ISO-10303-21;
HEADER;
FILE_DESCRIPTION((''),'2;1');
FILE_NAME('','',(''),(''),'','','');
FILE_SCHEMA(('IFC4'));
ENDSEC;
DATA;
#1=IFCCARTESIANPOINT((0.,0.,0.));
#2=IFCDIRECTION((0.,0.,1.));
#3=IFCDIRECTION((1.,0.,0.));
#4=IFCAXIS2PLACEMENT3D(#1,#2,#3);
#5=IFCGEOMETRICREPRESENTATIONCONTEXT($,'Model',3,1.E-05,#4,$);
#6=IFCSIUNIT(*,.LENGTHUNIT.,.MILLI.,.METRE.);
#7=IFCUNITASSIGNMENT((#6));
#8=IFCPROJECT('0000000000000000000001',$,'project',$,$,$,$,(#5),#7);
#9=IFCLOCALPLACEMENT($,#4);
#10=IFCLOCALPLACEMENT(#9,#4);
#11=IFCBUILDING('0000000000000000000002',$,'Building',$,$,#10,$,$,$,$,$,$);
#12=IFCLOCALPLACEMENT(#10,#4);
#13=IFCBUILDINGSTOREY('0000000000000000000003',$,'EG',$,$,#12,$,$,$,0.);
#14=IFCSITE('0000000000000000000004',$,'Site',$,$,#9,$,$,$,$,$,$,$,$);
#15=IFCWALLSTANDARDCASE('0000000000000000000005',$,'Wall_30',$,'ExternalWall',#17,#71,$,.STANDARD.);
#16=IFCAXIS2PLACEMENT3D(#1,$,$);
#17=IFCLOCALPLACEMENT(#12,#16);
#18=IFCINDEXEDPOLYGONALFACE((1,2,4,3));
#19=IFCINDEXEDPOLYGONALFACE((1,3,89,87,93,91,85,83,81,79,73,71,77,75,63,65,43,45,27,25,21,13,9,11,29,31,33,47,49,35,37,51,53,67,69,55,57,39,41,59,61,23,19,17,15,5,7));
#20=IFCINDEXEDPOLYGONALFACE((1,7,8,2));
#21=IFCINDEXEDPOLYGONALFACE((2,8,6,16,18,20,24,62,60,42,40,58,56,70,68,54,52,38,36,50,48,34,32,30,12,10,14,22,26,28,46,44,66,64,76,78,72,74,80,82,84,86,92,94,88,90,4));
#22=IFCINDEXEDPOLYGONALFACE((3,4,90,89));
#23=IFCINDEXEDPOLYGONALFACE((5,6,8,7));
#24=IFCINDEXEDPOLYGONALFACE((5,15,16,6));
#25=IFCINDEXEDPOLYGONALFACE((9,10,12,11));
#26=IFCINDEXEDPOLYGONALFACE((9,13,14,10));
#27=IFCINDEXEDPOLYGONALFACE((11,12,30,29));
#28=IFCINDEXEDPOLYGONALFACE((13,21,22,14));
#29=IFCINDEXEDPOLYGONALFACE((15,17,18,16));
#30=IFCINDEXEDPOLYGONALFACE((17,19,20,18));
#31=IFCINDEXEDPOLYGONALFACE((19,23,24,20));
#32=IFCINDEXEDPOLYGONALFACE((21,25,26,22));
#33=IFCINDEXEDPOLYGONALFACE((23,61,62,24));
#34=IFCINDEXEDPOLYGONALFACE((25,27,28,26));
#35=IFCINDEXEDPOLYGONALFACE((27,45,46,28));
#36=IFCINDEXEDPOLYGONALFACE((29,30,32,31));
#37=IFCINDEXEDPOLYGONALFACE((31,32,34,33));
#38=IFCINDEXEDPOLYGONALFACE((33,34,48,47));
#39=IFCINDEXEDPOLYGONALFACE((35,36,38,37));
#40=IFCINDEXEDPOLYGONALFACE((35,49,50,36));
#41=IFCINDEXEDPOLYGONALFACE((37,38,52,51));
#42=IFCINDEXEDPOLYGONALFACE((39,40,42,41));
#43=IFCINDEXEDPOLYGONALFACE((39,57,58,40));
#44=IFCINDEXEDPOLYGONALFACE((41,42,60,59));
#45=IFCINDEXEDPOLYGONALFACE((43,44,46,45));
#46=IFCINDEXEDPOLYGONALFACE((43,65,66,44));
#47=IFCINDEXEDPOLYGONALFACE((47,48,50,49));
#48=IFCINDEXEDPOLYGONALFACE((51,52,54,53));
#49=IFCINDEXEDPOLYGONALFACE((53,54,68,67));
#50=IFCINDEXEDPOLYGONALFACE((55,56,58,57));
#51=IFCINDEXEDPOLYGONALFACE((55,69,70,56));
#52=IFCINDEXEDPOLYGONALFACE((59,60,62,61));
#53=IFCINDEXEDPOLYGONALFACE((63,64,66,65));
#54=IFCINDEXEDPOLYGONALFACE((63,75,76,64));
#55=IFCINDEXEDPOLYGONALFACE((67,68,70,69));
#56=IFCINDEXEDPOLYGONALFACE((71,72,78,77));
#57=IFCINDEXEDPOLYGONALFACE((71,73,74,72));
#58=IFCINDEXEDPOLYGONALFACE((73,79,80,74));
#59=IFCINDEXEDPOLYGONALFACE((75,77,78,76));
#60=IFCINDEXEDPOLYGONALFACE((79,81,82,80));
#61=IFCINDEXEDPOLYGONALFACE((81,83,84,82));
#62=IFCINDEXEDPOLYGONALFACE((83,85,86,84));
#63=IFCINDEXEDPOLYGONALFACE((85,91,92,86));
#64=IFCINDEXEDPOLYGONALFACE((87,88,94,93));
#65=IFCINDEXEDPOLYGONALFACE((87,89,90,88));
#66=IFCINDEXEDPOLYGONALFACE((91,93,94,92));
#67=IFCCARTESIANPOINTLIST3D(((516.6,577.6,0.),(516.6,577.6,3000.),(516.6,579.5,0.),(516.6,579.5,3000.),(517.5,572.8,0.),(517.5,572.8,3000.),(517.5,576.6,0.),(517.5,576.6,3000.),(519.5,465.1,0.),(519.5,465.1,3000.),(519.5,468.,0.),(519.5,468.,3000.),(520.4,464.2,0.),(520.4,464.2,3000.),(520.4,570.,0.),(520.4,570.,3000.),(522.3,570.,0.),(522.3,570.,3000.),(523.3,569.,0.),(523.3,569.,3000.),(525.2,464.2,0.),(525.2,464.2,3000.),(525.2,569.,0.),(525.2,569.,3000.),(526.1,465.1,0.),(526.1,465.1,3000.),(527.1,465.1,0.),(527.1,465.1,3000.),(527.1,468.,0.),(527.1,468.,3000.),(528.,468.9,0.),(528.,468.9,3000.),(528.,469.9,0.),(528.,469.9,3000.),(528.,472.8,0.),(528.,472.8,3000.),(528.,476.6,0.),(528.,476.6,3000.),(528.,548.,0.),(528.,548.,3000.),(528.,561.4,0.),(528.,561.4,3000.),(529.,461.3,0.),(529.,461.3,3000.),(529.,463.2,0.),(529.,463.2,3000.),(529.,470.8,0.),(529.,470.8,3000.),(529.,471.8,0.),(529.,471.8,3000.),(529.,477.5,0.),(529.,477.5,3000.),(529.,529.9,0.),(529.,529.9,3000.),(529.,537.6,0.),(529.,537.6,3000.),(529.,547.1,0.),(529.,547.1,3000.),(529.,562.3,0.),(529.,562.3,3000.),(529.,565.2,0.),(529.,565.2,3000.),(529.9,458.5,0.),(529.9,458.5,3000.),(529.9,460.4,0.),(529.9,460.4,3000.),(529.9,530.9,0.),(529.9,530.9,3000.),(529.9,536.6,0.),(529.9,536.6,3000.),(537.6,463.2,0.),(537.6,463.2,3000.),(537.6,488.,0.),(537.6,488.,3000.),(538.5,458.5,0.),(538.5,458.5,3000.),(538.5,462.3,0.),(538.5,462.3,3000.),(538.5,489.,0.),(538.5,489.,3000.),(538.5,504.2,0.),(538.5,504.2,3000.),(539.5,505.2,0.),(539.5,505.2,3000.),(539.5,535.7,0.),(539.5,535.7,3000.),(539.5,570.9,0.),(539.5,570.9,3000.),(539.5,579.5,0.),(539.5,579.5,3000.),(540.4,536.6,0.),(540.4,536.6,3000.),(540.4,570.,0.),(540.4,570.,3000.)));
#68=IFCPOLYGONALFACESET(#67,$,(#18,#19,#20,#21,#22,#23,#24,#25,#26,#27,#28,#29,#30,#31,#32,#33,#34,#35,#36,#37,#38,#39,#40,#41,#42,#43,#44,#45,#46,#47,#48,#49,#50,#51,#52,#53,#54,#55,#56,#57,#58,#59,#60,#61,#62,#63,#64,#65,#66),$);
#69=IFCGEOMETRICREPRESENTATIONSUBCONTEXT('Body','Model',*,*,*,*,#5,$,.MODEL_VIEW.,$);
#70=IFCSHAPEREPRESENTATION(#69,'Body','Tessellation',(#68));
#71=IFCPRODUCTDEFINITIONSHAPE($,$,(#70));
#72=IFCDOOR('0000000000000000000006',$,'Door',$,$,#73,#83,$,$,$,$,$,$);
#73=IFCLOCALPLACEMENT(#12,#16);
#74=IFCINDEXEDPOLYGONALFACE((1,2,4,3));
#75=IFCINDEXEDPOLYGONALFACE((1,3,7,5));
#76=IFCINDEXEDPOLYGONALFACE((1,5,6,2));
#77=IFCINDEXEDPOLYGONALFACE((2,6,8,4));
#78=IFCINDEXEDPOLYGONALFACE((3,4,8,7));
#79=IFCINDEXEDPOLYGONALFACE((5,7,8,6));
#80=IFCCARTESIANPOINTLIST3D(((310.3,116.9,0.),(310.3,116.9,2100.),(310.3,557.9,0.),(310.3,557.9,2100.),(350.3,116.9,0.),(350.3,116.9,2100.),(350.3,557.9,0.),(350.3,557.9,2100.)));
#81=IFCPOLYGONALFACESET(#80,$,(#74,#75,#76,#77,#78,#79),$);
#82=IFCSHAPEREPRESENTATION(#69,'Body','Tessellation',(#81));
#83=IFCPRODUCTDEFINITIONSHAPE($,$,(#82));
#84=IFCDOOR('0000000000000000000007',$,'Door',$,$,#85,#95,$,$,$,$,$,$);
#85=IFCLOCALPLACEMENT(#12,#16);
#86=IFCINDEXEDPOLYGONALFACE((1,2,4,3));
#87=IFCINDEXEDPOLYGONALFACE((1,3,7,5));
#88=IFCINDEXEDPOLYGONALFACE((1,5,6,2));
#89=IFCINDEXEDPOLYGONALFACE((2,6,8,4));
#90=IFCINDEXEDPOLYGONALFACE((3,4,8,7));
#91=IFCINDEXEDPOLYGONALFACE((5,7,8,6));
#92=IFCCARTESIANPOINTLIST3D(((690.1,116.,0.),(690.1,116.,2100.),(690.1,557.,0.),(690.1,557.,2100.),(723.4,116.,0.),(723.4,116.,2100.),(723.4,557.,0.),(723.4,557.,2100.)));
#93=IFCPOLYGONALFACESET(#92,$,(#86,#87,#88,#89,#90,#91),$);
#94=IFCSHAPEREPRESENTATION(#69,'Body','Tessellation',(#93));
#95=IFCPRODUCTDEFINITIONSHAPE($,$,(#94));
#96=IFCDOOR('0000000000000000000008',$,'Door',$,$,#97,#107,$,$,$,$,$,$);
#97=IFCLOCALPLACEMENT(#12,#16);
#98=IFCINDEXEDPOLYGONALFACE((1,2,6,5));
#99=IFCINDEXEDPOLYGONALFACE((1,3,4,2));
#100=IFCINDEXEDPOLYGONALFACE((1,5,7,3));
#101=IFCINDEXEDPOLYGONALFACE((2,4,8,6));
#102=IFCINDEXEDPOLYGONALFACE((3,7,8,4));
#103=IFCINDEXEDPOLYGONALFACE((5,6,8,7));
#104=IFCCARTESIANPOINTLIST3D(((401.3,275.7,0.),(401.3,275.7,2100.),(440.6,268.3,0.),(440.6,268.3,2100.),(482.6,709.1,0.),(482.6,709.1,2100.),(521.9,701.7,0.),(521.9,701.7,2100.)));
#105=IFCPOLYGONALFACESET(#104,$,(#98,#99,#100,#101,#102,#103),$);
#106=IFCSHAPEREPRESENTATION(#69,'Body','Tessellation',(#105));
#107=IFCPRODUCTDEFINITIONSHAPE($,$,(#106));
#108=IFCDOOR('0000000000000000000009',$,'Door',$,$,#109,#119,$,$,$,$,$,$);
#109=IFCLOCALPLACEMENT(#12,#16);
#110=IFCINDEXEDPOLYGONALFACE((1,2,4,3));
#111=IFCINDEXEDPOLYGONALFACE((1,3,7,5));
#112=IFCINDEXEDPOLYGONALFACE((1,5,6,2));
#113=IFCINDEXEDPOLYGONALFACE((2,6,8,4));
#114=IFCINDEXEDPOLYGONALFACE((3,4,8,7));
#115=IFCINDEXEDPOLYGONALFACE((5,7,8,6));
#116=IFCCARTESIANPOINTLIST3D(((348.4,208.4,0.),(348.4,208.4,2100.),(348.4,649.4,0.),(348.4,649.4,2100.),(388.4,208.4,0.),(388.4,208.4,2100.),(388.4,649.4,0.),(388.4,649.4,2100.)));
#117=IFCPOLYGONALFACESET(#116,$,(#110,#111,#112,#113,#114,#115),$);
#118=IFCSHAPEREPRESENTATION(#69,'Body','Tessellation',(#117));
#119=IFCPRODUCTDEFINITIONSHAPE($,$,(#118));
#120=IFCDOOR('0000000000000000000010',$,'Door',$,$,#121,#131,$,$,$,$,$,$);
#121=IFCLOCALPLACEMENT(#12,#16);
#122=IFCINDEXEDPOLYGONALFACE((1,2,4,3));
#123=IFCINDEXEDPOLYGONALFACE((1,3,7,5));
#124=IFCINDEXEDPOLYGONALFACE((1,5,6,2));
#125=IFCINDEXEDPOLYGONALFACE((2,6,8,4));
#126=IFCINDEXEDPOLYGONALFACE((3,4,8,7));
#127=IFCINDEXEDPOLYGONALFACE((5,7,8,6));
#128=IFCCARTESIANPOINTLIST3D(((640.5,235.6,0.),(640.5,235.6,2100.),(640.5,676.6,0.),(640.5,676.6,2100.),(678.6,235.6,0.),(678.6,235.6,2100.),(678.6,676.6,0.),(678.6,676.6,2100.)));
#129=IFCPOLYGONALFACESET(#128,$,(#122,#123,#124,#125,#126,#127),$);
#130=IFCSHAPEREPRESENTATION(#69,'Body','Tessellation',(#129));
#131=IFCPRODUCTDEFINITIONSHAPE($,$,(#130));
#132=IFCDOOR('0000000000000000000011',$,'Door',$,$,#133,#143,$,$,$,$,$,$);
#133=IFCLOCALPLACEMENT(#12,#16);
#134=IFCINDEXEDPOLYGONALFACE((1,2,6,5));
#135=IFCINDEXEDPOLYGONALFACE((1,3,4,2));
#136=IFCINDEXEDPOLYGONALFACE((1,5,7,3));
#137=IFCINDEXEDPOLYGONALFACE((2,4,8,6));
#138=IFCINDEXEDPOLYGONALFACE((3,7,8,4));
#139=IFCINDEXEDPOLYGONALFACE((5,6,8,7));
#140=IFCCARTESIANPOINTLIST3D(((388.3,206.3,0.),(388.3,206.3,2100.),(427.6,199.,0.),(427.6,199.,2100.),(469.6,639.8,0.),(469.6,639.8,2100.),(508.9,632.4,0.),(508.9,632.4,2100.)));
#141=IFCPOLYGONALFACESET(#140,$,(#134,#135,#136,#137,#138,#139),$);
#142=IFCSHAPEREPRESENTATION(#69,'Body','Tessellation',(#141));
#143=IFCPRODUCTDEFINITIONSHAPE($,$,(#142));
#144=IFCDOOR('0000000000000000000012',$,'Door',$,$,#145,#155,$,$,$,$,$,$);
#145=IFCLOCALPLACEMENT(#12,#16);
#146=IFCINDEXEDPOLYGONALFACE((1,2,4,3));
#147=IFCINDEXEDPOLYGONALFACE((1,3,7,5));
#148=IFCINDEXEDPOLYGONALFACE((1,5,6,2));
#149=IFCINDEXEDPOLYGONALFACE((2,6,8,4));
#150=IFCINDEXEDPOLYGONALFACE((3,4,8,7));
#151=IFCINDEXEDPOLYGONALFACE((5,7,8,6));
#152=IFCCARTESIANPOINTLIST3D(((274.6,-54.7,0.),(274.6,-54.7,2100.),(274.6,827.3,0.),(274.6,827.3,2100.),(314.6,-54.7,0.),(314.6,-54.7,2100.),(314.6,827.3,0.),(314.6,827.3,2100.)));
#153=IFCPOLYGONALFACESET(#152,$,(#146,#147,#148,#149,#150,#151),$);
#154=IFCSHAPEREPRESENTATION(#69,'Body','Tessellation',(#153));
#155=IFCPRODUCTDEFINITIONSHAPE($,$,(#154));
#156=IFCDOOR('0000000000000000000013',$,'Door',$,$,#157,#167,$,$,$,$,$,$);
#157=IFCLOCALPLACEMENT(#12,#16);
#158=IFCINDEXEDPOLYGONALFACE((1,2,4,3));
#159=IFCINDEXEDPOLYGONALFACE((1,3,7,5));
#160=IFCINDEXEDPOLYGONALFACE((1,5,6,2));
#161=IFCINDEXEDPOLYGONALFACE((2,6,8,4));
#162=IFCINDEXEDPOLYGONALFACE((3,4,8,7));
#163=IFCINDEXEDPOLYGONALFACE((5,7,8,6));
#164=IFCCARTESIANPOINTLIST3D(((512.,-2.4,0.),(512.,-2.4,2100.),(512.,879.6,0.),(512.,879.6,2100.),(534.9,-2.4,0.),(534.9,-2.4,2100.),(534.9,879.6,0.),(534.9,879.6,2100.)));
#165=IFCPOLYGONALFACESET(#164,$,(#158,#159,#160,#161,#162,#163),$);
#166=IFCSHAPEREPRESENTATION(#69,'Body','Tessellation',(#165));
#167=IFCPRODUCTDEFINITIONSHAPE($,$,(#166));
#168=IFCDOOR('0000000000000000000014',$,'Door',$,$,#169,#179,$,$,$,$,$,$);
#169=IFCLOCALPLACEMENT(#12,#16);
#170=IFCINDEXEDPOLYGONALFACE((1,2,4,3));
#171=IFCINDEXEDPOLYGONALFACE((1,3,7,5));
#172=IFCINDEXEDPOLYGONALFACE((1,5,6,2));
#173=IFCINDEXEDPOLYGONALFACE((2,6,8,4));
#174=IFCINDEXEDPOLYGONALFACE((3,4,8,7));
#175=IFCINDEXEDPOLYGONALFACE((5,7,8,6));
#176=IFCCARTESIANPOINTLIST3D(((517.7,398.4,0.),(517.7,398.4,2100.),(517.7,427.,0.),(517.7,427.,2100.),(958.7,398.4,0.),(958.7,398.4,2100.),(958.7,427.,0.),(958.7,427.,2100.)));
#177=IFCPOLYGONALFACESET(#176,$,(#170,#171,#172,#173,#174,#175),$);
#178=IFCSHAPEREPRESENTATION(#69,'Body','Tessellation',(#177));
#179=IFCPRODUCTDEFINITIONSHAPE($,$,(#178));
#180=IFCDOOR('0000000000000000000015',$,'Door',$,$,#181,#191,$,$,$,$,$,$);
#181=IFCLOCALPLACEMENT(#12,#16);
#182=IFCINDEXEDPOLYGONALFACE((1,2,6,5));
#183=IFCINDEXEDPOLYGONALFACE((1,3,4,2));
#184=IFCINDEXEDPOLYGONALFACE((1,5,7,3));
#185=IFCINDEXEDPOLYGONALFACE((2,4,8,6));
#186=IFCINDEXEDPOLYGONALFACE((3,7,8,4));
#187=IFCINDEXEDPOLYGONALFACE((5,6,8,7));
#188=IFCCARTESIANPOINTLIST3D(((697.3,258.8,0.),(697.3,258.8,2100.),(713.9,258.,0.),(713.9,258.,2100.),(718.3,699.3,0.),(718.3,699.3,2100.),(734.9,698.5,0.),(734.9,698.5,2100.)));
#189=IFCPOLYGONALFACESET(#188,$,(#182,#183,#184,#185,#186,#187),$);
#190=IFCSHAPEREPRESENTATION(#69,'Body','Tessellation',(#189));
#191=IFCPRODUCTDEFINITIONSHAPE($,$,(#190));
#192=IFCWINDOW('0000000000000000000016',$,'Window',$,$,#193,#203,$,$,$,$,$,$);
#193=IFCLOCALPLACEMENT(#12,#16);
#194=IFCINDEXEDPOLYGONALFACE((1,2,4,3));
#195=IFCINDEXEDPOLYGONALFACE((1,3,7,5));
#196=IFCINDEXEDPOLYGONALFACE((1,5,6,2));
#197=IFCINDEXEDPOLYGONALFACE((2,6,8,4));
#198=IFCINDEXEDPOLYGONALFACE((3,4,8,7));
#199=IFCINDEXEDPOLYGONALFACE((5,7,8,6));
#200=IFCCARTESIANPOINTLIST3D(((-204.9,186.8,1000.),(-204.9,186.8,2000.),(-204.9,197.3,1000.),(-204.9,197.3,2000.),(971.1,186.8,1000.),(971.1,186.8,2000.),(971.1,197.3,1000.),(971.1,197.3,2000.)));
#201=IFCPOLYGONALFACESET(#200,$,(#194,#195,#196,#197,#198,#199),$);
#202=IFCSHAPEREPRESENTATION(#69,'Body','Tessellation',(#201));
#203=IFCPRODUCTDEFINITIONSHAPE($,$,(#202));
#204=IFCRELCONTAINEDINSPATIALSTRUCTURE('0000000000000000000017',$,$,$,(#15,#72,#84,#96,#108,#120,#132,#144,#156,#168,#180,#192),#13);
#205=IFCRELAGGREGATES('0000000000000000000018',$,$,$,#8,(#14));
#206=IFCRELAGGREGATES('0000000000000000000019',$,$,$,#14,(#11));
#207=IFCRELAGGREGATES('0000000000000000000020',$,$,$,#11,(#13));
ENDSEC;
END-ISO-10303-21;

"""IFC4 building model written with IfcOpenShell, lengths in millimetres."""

from ifc_helpers import new_model, si_unit, frame, origin_with_axes, place, context, subcontext, project, spatial, polyline, rectangle, outline, extrude, element, save


model = new_model("IFC4")

# Units and contexts
model_context = context("Model", 3, precision=1e-05, world=origin_with_axes())
body_context = subcontext(model_context, "Body", "Model", "MODEL_VIEW")
ifc_project = project(units=[si_unit("LENGTHUNIT", "METRE", prefix="MILLI")], contexts=[model_context])

# Site, building, storey
site_placement = place(None, origin_with_axes())
site = spatial("IfcSite", under=ifc_project, at=site_placement, Name="Site")
building_placement = place(site_placement, origin_with_axes())
building = spatial("IfcBuilding", under=site, at=building_placement, Name="Building")
storey_placement = place(building_placement, origin_with_axes())
storey = spatial("IfcBuildingStorey", under=building, at=storey_placement, Name="EG", Elevation=0.0)

# Wall
wall_placement = place(storey_placement, origin_with_axes())
element("IfcWallStandardCase", 1, at=wall_placement, inside=storey, Name="Wall_30", ObjectType="ExternalWall", PredefinedType="STANDARD", context=body_context, shape_type="SweptSolid", body=[
    extrude(outline(polyline([(529.9, 458.5, 0.0), (529.9, 460.4, 0.0), (529.0, 461.3, 0.0), (529.0, 463.2, 0.0), (527.1, 465.1, 0.0), (526.1, 465.1, 0.0), (525.2, 464.2, 0.0), (520.4, 464.2, 0.0), (519.5, 465.1, 0.0), (519.5, 468.0, 0.0), (527.1, 468.0, 0.0), (528.0, 468.9, 0.0), (528.0, 469.9, 0.0), (529.0, 470.8, 0.0), (529.0, 471.8, 0.0), (528.0, 472.8, 0.0), (528.0, 476.6, 0.0), (529.0, 477.5, 0.0), (529.0, 529.9, 0.0), (529.9, 530.9, 0.0), (529.9, 536.6, 0.0), (529.0, 537.6, 0.0), (529.0, 547.1, 0.0), (528.0, 548.0, 0.0), (528.0, 561.4, 0.0), (529.0, 562.3, 0.0), (529.0, 565.2, 0.0), (525.2, 569.0, 0.0), (523.3, 569.0, 0.0), (522.3, 570.0, 0.0), (520.4, 570.0, 0.0), (517.5, 572.8, 0.0), (517.5, 576.6, 0.0), (516.6, 577.6, 0.0), (516.6, 579.5, 0.0), (539.5, 579.5, 0.0), (539.5, 570.9, 0.0), (540.4, 570.0, 0.0), (540.4, 536.6, 0.0), (539.5, 535.7, 0.0), (539.5, 505.2, 0.0), (538.5, 504.2, 0.0), (538.5, 489.0, 0.0), (537.6, 488.0, 0.0), (537.6, 463.2, 0.0), (538.5, 462.3, 0.0), (538.5, 458.5, 0.0), (529.9, 458.5, 0.0)])), origin_with_axes(), (0.0, 0.0, 1.0), 3000.0),
])

# Doors
door_1_placement = place(storey_placement, origin_with_axes())
element("IfcDoor", 2, at=door_1_placement, inside=storey, Name="Door", context=body_context, shape_type="SweptSolid", body=[
    extrude(rectangle(XDim=441.0, YDim=40.0), frame((330.3, 337.4, 0.0), z_axis=(0.0, 0.0, 1.0), x_axis=(0.0, 1.0, 0.0)), (0.0, 0.0, 1.0), 2100.0),
])
door_2_placement = place(storey_placement, origin_with_axes())
element("IfcDoor", 3, at=door_2_placement, inside=storey, Name="Door", context=body_context, shape_type="SweptSolid", body=[
    extrude(rectangle(XDim=441.0, YDim=33.4), frame((706.7, 336.5, 0.0), z_axis=(0.0, 0.0, 1.0), x_axis=(0.0, 1.0, 0.0)), (0.0, 0.0, 1.0), 2100.0),
])
door_3_placement = place(storey_placement, origin_with_axes())
element("IfcDoor", 4, at=door_3_placement, inside=storey, Name="Door", context=body_context, shape_type="SweptSolid", body=[
    extrude(rectangle(XDim=441.0, YDim=40.0), frame((461.6, 488.7, 0.0), z_axis=(0.0, 0.0, 1.0), x_axis=(-0.184288, -0.982872, 0.0)), (0.0, 0.0, 1.0), 2100.0),
])
door_4_placement = place(storey_placement, origin_with_axes())
element("IfcDoor", 5, at=door_4_placement, inside=storey, Name="Door", context=body_context, shape_type="SweptSolid", body=[
    extrude(rectangle(XDim=441.0, YDim=40.0), frame((368.4, 428.9, 0.0), z_axis=(0.0, 0.0, 1.0), x_axis=(0.0, -1.0, 0.0)), (0.0, 0.0, 1.0), 2100.0),
])
door_5_placement = place(storey_placement, origin_with_axes())
element("IfcDoor", 6, at=door_5_placement, inside=storey, Name="Door", context=body_context, shape_type="SweptSolid", body=[
    extrude(rectangle(XDim=441.0, YDim=38.1), frame((659.6, 456.1, 0.0), z_axis=(0.0, 0.0, 1.0), x_axis=(0.0, 1.0, 0.0)), (0.0, 0.0, 1.0), 2100.0),
])
door_6_placement = place(storey_placement, origin_with_axes())
element("IfcDoor", 7, at=door_6_placement, inside=storey, Name="Door", context=body_context, shape_type="SweptSolid", body=[
    extrude(rectangle(XDim=441.0, YDim=40.0), frame((448.6, 419.4, 0.0), z_axis=(0.0, 0.0, 1.0), x_axis=(-0.184288, -0.982872, 0.0)), (0.0, 0.0, 1.0), 2100.0),
])
door_7_placement = place(storey_placement, origin_with_axes())
element("IfcDoor", 8, at=door_7_placement, inside=storey, Name="Door", context=body_context, shape_type="SweptSolid", body=[
    extrude(rectangle(XDim=882.0, YDim=40.0), frame((294.6, 386.3, 0.0), z_axis=(0.0, 0.0, 1.0), x_axis=(0.0, 1.0, 0.0)), (0.0, 0.0, 1.0), 2100.0),
])
door_8_placement = place(storey_placement, origin_with_axes())
element("IfcDoor", 9, at=door_8_placement, inside=storey, Name="Door", context=body_context, shape_type="SweptSolid", body=[
    extrude(rectangle(XDim=882.0, YDim=22.9), frame((523.4, 438.6, 0.0), z_axis=(0.0, 0.0, 1.0), x_axis=(0.0, 1.0, 0.0)), (0.0, 0.0, 1.0), 2100.0),
])
door_9_placement = place(storey_placement, origin_with_axes())
element("IfcDoor", 10, at=door_9_placement, inside=storey, Name="Door", context=body_context, shape_type="SweptSolid", body=[
    extrude(rectangle(XDim=441.0, YDim=28.6), frame((738.2, 412.7, 0.0), z_axis=(0.0, 0.0, 1.0), x_axis=(1.0, 0.0, 0.0)), (0.0, 0.0, 1.0), 2100.0),
])
door_10_placement = place(storey_placement, origin_with_axes())
element("IfcDoor", 11, at=door_10_placement, inside=storey, Name="Door", context=body_context, shape_type="SweptSolid", body=[
    extrude(rectangle(XDim=441.0, YDim=16.6), frame((716.1, 478.6, 0.0), z_axis=(0.0, 0.0, 1.0), x_axis=(-0.047565, -0.998868, 0.0)), (0.0, 0.0, 1.0), 2100.0),
])

# Window
window_1_placement = place(storey_placement, origin_with_axes())
element("IfcWindow", 12, at=window_1_placement, inside=storey, Name="Window", context=body_context, shape_type="SweptSolid", body=[
    extrude(rectangle(XDim=1176.0, YDim=10.5), frame((383.1, 192.1, 1000.0), z_axis=(0.0, 0.0, 1.0), x_axis=(1.0, 0.0, 0.0)), (0.0, 0.0, 1.0), 1000.0),
])

save(model, "model.ifc")
